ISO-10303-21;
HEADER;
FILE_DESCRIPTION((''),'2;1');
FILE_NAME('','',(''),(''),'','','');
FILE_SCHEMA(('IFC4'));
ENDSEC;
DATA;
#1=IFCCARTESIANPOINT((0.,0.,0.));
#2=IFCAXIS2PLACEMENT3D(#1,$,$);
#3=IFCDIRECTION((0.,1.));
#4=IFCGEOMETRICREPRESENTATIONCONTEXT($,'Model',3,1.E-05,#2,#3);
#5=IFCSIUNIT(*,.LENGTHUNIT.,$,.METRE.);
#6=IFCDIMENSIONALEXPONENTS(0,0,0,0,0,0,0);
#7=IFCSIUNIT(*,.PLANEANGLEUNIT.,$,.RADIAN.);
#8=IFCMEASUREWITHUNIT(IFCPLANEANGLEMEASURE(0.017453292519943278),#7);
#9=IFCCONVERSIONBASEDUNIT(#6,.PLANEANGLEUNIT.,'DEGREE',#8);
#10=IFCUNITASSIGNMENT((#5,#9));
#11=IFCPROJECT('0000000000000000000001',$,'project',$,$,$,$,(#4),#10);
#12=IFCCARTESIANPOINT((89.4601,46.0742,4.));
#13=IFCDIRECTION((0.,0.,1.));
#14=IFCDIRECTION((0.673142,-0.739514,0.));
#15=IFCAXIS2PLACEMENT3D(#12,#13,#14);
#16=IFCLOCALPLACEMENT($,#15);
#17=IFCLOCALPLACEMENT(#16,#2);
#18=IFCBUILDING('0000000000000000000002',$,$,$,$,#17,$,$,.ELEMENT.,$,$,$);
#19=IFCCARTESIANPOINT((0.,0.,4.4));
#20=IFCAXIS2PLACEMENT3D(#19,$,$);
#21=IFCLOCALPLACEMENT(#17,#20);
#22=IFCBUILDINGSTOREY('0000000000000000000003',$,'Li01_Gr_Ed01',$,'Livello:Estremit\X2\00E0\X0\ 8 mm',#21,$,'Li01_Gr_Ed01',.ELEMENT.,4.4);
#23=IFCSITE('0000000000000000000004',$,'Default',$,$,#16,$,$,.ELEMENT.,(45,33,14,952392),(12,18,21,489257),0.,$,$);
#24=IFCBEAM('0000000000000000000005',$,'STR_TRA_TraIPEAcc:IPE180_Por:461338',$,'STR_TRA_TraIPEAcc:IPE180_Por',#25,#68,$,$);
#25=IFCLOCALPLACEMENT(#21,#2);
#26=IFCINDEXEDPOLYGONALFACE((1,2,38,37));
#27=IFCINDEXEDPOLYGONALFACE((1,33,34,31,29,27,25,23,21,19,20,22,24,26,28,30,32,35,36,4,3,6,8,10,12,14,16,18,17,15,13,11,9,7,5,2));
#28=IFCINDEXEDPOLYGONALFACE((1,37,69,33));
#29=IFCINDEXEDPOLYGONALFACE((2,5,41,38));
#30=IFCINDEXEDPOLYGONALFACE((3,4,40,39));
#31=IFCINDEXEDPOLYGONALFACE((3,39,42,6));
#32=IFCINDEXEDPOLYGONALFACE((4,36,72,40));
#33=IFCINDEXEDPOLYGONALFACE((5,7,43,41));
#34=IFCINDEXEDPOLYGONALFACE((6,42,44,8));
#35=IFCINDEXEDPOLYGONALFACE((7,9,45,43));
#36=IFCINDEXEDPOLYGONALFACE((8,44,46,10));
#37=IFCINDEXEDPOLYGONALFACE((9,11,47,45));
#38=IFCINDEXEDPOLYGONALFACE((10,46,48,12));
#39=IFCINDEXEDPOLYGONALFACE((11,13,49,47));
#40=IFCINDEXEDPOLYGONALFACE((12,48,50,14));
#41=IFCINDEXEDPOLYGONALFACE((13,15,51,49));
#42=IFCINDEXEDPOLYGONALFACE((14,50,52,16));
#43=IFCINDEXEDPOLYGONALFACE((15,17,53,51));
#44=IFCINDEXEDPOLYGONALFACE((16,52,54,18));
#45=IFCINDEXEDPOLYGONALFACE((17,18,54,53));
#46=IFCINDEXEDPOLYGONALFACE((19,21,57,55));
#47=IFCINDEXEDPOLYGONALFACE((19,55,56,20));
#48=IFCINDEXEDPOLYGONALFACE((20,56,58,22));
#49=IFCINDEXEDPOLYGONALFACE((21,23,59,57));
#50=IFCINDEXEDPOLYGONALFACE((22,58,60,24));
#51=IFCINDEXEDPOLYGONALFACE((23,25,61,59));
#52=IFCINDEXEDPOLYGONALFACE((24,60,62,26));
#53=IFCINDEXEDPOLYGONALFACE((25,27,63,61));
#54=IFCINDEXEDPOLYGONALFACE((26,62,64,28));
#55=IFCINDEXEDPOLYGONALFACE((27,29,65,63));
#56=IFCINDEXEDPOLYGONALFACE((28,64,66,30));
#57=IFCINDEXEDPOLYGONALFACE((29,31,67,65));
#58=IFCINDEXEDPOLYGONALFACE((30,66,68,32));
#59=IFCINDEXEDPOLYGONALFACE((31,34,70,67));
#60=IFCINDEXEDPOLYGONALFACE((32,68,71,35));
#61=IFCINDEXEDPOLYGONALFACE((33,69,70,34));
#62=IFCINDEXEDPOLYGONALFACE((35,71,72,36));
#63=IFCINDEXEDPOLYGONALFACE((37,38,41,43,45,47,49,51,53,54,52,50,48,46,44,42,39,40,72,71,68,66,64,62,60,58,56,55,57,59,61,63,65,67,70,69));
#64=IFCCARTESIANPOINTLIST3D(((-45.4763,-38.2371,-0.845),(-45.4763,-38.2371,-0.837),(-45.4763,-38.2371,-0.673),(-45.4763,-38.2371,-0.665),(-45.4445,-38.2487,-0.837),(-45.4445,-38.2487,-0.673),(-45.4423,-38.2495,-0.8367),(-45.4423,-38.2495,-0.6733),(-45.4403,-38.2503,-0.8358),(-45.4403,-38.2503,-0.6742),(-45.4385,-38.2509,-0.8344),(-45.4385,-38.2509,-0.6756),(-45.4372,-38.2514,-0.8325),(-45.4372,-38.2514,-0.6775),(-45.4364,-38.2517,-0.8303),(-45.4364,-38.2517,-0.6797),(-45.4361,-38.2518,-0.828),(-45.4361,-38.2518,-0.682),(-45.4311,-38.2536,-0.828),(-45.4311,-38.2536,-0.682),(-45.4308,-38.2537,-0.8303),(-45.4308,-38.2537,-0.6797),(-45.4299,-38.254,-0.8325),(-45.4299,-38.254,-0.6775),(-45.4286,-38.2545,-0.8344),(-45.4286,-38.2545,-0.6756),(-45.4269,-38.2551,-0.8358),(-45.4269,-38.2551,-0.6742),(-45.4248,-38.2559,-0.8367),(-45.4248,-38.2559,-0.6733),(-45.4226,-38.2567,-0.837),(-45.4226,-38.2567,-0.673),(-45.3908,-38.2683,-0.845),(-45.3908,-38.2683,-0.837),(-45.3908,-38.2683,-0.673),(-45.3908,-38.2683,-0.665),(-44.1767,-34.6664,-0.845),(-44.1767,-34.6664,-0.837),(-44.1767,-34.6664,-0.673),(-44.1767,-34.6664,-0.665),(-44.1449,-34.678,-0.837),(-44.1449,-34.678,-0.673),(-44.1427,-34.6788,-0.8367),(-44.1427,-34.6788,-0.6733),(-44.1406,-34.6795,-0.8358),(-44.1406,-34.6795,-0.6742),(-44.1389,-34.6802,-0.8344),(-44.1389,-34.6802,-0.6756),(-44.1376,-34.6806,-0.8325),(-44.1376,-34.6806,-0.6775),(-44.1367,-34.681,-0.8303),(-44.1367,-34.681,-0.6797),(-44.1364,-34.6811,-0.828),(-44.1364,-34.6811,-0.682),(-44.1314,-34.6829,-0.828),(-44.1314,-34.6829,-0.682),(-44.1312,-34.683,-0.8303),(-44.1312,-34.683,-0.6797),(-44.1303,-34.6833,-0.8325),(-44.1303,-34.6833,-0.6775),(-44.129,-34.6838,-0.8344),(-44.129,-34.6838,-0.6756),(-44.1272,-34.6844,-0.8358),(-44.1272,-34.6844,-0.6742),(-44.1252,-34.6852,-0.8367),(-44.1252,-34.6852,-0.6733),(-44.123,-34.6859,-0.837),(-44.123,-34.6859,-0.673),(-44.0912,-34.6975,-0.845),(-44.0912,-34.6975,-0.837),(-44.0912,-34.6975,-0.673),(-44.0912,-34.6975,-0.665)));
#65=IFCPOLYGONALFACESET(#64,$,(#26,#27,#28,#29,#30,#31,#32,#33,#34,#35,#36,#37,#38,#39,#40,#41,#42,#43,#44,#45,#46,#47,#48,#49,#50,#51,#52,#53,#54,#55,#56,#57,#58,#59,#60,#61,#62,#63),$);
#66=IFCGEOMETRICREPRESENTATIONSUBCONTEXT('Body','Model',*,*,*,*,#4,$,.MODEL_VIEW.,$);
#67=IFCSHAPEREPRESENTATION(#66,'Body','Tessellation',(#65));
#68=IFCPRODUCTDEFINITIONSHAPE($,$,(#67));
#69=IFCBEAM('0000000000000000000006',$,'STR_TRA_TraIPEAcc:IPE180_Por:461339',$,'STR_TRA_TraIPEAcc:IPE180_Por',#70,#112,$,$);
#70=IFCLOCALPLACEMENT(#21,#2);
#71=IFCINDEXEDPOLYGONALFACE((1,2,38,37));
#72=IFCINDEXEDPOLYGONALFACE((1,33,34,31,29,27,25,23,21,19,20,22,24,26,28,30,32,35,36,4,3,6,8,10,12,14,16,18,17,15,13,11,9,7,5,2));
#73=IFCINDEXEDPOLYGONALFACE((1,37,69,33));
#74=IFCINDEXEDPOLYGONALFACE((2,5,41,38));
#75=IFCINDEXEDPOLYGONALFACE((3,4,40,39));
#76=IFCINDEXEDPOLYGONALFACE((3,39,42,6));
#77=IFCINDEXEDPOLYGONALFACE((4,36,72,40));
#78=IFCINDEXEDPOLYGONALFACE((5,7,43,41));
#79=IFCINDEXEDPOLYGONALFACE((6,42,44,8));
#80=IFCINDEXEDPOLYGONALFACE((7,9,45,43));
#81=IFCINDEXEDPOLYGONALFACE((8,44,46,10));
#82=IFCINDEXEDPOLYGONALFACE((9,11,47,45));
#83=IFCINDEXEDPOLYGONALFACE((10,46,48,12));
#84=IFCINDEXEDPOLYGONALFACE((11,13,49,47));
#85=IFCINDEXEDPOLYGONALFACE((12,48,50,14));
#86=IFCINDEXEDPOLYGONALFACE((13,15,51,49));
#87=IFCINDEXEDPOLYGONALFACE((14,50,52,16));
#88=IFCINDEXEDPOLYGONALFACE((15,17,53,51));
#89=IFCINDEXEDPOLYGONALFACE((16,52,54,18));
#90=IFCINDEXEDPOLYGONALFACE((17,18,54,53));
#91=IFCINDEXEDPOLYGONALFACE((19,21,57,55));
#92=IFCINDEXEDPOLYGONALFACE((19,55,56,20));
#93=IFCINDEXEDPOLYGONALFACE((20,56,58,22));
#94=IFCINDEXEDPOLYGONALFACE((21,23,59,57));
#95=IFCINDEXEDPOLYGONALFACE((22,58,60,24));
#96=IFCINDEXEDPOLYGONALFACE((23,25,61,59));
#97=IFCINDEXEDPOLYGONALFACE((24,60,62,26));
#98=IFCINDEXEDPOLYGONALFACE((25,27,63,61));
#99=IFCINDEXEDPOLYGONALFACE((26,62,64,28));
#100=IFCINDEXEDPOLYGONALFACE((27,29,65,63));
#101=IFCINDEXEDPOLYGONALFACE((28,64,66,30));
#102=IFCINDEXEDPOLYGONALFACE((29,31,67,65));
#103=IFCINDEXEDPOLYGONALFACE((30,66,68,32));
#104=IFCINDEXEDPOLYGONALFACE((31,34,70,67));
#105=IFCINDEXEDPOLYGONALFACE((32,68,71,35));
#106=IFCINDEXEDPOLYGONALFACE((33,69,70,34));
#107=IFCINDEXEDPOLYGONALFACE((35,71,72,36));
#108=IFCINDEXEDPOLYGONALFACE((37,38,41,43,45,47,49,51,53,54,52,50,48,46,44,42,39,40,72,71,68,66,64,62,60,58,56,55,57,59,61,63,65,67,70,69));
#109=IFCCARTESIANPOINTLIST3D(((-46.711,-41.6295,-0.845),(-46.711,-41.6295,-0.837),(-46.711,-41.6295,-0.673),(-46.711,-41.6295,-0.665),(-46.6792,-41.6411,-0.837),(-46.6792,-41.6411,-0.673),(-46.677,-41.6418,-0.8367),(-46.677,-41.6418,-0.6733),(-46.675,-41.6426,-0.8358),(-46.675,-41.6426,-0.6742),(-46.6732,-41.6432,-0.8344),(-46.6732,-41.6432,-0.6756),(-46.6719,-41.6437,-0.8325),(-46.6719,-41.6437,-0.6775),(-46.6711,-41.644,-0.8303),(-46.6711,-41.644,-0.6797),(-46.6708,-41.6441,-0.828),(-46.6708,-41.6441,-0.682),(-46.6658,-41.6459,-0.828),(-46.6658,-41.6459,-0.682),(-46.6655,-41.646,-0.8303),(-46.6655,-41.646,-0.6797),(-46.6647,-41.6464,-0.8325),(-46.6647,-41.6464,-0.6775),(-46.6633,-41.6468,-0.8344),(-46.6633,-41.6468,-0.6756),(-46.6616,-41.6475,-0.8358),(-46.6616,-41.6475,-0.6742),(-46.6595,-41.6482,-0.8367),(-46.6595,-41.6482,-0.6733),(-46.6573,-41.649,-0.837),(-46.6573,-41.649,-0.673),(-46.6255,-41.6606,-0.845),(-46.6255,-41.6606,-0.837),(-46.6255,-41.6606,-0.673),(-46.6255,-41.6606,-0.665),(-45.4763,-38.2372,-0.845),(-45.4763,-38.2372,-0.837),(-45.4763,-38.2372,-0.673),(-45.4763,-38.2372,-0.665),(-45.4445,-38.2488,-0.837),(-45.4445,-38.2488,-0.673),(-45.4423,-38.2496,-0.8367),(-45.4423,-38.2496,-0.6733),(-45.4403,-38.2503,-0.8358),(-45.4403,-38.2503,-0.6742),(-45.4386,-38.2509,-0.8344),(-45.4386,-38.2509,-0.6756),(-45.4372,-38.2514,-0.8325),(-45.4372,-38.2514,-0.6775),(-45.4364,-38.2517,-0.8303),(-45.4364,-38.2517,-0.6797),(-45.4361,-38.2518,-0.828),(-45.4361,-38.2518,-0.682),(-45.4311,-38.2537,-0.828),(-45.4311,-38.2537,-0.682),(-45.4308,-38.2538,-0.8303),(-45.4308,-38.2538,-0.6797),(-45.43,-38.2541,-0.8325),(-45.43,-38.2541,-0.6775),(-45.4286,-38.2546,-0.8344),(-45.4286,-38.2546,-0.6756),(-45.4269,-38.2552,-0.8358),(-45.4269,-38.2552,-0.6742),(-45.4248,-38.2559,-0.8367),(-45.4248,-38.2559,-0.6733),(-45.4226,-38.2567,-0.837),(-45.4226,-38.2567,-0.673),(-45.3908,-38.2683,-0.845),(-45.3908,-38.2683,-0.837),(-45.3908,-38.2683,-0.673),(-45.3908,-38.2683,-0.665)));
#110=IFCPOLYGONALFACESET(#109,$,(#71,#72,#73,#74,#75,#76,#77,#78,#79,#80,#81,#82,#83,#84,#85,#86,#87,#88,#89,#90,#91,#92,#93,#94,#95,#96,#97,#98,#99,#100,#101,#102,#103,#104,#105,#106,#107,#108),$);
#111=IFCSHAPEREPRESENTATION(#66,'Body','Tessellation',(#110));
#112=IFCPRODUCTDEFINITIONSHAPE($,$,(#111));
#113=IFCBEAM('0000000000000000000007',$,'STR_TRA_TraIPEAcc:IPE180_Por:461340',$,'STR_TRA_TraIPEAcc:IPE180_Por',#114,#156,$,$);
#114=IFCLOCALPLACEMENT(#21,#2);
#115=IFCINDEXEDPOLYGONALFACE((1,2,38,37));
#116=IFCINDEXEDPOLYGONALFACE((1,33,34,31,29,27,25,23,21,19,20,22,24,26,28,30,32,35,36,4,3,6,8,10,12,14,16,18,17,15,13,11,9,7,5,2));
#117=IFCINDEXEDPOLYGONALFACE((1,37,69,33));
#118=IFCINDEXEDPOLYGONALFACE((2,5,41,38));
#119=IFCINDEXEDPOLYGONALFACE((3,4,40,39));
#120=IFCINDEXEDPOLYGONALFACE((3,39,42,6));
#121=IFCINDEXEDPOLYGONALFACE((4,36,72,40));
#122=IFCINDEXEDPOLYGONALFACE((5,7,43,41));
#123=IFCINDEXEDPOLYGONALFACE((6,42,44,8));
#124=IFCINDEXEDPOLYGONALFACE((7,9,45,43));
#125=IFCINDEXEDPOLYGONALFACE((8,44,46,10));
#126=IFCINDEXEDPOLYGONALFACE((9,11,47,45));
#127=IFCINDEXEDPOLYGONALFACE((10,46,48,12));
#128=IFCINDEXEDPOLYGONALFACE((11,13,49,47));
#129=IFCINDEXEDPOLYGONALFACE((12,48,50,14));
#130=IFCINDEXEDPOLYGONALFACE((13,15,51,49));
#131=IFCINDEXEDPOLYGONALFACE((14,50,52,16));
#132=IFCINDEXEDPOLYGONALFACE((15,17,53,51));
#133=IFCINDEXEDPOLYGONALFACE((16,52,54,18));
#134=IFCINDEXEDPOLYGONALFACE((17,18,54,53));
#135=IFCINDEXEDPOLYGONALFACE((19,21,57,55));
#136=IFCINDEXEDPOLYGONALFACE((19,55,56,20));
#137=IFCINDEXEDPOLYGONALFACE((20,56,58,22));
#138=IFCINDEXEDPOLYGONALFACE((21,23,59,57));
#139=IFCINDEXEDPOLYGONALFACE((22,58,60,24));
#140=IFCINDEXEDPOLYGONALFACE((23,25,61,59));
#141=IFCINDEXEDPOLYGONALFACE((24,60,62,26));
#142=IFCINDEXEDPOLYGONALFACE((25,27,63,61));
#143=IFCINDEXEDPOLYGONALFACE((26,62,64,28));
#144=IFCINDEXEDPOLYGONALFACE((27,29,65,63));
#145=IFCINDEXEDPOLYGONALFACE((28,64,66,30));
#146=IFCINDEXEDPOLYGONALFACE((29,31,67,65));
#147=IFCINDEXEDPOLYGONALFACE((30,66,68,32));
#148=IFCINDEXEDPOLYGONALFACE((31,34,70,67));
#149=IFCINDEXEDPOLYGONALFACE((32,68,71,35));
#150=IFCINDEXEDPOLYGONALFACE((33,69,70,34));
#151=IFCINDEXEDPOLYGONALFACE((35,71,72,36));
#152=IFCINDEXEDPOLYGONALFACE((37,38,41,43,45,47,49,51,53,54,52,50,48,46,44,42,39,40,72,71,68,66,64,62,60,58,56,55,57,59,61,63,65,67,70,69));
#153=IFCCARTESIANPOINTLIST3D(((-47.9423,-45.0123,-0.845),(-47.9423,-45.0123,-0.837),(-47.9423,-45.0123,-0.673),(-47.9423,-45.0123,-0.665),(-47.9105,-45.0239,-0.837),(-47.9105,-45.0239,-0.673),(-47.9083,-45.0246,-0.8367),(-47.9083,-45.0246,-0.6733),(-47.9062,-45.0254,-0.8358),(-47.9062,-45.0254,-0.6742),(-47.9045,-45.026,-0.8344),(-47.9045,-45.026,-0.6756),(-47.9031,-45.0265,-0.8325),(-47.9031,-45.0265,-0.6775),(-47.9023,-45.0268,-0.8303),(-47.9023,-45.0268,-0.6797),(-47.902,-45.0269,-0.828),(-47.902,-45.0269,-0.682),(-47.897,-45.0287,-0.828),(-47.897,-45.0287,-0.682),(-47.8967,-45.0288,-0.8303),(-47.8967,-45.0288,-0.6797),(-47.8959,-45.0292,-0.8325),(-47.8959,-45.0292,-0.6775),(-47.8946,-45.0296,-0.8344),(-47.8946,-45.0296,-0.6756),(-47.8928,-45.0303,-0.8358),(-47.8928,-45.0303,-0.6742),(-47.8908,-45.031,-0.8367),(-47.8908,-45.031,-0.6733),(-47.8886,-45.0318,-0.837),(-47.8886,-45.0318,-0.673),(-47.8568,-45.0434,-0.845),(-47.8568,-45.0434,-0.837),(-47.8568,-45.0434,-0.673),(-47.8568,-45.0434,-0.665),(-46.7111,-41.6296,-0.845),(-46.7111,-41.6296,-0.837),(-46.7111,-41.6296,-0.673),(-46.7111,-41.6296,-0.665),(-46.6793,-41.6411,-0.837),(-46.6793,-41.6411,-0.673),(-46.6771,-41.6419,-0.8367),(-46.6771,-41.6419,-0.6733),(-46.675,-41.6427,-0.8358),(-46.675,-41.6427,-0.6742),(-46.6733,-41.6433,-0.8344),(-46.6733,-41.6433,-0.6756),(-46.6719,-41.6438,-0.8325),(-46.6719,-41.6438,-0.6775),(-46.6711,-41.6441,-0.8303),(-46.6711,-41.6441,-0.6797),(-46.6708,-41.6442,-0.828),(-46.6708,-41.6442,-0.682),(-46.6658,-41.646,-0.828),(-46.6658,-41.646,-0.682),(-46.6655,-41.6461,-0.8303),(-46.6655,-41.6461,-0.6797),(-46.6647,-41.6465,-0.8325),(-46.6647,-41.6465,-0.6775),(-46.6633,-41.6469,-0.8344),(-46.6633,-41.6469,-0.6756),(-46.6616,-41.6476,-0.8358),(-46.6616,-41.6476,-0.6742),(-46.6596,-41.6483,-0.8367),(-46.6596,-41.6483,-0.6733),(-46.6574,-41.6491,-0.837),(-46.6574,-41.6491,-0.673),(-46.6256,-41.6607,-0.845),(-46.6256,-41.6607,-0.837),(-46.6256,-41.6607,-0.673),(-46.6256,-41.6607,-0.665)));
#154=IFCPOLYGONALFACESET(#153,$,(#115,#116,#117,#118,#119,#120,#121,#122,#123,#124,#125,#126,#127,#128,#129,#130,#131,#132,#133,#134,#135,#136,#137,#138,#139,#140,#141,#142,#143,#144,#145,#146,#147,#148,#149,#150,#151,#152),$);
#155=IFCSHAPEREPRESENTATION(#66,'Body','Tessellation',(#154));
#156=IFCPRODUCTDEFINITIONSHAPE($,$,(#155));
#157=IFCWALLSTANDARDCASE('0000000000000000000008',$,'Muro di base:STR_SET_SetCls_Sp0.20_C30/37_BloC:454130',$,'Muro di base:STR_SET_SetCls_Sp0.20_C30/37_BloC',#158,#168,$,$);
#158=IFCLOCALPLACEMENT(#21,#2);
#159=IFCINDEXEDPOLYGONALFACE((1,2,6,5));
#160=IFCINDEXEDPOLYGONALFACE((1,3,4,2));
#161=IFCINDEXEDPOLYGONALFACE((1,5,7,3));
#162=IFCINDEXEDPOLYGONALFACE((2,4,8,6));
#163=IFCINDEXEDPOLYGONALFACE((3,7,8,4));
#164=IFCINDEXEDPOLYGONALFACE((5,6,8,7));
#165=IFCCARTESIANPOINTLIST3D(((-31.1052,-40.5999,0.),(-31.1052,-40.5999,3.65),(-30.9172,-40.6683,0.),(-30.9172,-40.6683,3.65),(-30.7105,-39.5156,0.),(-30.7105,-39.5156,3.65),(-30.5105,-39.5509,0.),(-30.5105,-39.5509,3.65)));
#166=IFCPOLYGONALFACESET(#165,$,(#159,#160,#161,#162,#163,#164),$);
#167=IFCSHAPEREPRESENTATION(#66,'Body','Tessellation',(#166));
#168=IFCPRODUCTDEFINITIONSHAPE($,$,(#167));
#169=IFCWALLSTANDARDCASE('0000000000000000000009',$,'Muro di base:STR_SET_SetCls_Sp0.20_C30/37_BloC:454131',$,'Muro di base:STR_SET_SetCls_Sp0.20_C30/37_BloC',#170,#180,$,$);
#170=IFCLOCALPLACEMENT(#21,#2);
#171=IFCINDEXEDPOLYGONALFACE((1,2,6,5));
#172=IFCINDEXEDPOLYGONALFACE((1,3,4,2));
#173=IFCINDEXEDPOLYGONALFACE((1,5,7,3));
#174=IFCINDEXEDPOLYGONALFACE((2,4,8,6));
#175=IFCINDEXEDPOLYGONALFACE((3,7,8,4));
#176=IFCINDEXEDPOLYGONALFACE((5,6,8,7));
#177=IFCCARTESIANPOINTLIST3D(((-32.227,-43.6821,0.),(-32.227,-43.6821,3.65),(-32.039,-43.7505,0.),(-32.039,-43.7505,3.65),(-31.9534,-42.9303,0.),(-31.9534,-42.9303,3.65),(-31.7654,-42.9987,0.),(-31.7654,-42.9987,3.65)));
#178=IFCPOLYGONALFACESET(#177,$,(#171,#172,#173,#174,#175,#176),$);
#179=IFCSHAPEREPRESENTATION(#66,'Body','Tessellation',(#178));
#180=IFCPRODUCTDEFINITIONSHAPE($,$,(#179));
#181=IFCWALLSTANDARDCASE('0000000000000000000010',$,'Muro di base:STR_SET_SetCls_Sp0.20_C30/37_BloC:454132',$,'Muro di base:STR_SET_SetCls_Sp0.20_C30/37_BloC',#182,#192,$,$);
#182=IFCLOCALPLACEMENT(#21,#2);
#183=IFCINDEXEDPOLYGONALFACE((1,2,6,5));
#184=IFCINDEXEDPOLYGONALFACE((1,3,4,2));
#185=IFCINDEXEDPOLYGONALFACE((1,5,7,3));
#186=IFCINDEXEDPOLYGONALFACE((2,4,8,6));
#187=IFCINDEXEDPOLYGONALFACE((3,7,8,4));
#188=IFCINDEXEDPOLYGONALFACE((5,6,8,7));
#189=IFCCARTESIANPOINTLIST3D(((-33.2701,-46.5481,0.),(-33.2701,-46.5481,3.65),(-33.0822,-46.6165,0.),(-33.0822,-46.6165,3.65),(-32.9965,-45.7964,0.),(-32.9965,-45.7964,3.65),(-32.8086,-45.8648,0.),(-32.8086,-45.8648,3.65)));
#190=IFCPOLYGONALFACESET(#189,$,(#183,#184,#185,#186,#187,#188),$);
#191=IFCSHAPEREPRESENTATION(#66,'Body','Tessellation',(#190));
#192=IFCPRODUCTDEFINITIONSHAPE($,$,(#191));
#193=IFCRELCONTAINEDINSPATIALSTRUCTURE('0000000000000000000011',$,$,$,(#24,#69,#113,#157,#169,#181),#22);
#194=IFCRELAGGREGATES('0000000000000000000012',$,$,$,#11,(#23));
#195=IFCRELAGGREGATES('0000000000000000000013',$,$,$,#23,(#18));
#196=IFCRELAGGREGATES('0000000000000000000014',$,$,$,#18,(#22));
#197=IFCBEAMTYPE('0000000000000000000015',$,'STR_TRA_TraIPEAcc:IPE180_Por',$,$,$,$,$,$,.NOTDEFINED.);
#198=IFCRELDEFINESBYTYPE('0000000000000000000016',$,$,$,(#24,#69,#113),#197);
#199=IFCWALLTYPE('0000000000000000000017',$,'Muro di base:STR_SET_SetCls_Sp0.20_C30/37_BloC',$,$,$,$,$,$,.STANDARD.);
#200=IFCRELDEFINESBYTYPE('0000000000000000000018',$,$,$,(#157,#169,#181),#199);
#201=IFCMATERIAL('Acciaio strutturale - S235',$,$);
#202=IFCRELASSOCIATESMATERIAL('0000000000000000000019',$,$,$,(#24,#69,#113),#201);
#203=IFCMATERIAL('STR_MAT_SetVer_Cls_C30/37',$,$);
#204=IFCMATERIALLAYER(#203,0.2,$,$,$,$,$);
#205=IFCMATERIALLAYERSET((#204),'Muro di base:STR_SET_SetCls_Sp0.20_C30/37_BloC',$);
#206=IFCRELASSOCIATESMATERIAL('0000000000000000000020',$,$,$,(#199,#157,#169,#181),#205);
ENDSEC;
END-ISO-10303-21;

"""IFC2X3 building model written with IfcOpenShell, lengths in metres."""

from ifc_helpers import new_model, entity, si_unit, converted_unit, direction, frame, frame_2d, origin, place, context, subcontext, project, spatial, polyline, rectangle, i_section, outline, extrude, material, layer, layer_set, layer_usage, type_object, element, save


model = new_model("IFC2X3")

# Units and contexts
model_context = context("Model", 3, precision=1e-05, world=origin(), true_north=direction((0.0, 1.0)))
body_context = subcontext(model_context, "Body", "Model", "MODEL_VIEW")
ifc_project = project(units=[si_unit("LENGTHUNIT", "METRE"), converted_unit("PLANEANGLEUNIT", "DEGREE", entity("IfcPlaneAngleMeasure", 0.017453292519943278), si_unit("PLANEANGLEUNIT", "RADIAN"), dimensions=[0, 0, 0, 0, 0, 0, 0])], contexts=[model_context])

# Site, building, storey
site_placement = place(None, frame((89.4601, 46.0742, 4.0), z_axis=(0.0, 0.0, 1.0), x_axis=(0.673142, -0.739514, 0.0)))
site = spatial("IfcSite", under=ifc_project, at=site_placement, Name="Default", CompositionType="ELEMENT", RefLatitude=(45, 33, 14, 952392), RefLongitude=(12, 18, 21, 489257), RefElevation=0.0)
building_placement = place(site_placement, origin())
building = spatial("IfcBuilding", under=site, at=building_placement, CompositionType="ELEMENT")
storey_placement = place(building_placement, frame((0.0, 0.0, 4.4)))
storey = spatial("IfcBuildingStorey", under=building, at=storey_placement, Name="Li01_Gr_Ed01", ObjectType="Livello:Estremità 8 mm", LongName="Li01_Gr_Ed01", CompositionType="ELEMENT", Elevation=4.4)

# Beams
ifc_material_1 = material(Name="Acciaio strutturale - S235")
beam_type = type_object("IfcBeamType", Name="STR_TRA_TraIPEAcc:IPE180_Por", PredefinedType="NOTDEFINED")
beam_1_placement = place(storey_placement, frame((-45.4336, -38.2527, -0.665), z_axis=(0.0, 0.0, 1.0), x_axis=(0.34202, 0.939693, 0.0)))
element("IfcBeam", 1, at=beam_1_placement, inside=storey, type_object=beam_type, material=ifc_material_1, Name="STR_TRA_TraIPEAcc:IPE180_Por:461338", ObjectType="STR_TRA_TraIPEAcc:IPE180_Por", context=body_context, shape_type="SweptSolid", body=[
    extrude(i_section(OverallWidth=0.091, OverallDepth=0.18, WebThickness=0.0053, FlangeThickness=0.008, FilletRadius=0.009, at=frame_2d((0.0, 0.0), x_axis=(0.0, 1.0))), frame((0.0, 0.0, -0.09), z_axis=(1.0, 0.0, 0.0), x_axis=(0.0, 0.0, -1.0)), (0.0, 0.0, 1.0), 3.7999),
])
beam_2_placement = place(storey_placement, frame((-46.6683, -41.645, -0.665), z_axis=(0.0, 0.0, 1.0), x_axis=(0.34202, 0.939693, 0.0)))
element("IfcBeam", 2, at=beam_2_placement, inside=storey, type_object=beam_type, material=ifc_material_1, Name="STR_TRA_TraIPEAcc:IPE180_Por:461339", ObjectType="STR_TRA_TraIPEAcc:IPE180_Por", context=body_context, shape_type="SweptSolid", body=[
    extrude(i_section(OverallWidth=0.091, OverallDepth=0.18, WebThickness=0.0053, FlangeThickness=0.008, FilletRadius=0.009, at=frame_2d((0.0, 0.0), x_axis=(0.0, 1.0))), frame((0.0, 0.0, -0.09), z_axis=(1.0, 0.0, 0.0), x_axis=(0.0, 0.0, -1.0)), (0.0, 0.0, 1.0), 3.61),
])
beam_3_placement = place(storey_placement, frame((-47.8996, -45.0279, -0.665), z_axis=(0.0, 0.0, 1.0), x_axis=(0.34202, 0.939693, 0.0)))
element("IfcBeam", 3, at=beam_3_placement, inside=storey, type_object=beam_type, material=ifc_material_1, Name="STR_TRA_TraIPEAcc:IPE180_Por:461340", ObjectType="STR_TRA_TraIPEAcc:IPE180_Por", context=body_context, shape_type="SweptSolid", body=[
    extrude(i_section(OverallWidth=0.091, OverallDepth=0.18, WebThickness=0.0053, FlangeThickness=0.008, FilletRadius=0.009, at=frame_2d((0.0, 0.0), x_axis=(0.0, 1.0))), frame((0.0001, 0.0, -0.09), z_axis=(1.0, 0.0, 0.0), x_axis=(0.0, 0.0, -1.0)), (0.0, 0.0, 1.0), 3.5998),
])

# Walls
ifc_material_2 = material(Name="STR_MAT_SetVer_Cls_C30/37")
ifc_layer_1 = layer(ifc_material_2, 0.2)
ifc_layer_set_1 = layer_set([ifc_layer_1], Name="Muro di base:STR_SET_SetCls_Sp0.20_C30/37_BloC")
ifc_layer_usage_1 = layer_usage(ifc_layer_set_1, "AXIS2", "NEGATIVE", 0.1)
wall_type_1 = type_object("IfcWallType", Name="Muro di base:STR_SET_SetCls_Sp0.20_C30/37_BloC", PredefinedType="STANDARD", material=ifc_layer_set_1)
wall_1_placement = place(storey_placement, frame((-31.0112, -40.6341, 0.0), z_axis=(0.0, 0.0, 1.0), x_axis=(0.34202, 0.939693, 0.0)))
element("IfcWallStandardCase", 4, at=wall_1_placement, inside=storey, type_object=wall_type_1, material=ifc_layer_usage_1, Name="Muro di base:STR_SET_SetCls_Sp0.20_C30/37_BloC:454130", ObjectType="Muro di base:STR_SET_SetCls_Sp0.20_C30/37_BloC", context=body_context, shape_type="SweptSolid", body=[
    extrude(outline(polyline([(1.1891, -0.1), (1.1539, 0.1), (0.0, 0.1), (0.0, -0.1), (1.1891, -0.1)])), origin(), (0.0, 0.0, 1.0), 3.65),
])
wall_2_placement = place(storey_placement, frame((-32.133, -43.7163, 0.0), z_axis=(0.0, 0.0, 1.0), x_axis=(0.34202, 0.939693, 0.0)))
element("IfcWallStandardCase", 5, at=wall_2_placement, inside=storey, type_object=wall_type_1, material=ifc_layer_usage_1, Name="Muro di base:STR_SET_SetCls_Sp0.20_C30/37_BloC:454131", ObjectType="Muro di base:STR_SET_SetCls_Sp0.20_C30/37_BloC", context=body_context, shape_type="SweptSolid", body=[
    extrude(rectangle(XDim=0.8, YDim=0.2, at=frame_2d((0.4, 0.0), x_axis=(-1.0, 0.0))), origin(), (0.0, 0.0, 1.0), 3.65),
])
wall_3_placement = place(storey_placement, frame((-33.1762, -46.5823, 0.0), z_axis=(0.0, 0.0, 1.0), x_axis=(0.34202, 0.939693, 0.0)))
element("IfcWallStandardCase", 6, at=wall_3_placement, inside=storey, type_object=wall_type_1, material=ifc_layer_usage_1, Name="Muro di base:STR_SET_SetCls_Sp0.20_C30/37_BloC:454132", ObjectType="Muro di base:STR_SET_SetCls_Sp0.20_C30/37_BloC", context=body_context, shape_type="SweptSolid", body=[
    extrude(rectangle(XDim=0.8, YDim=0.2, at=frame_2d((0.4, 0.0), x_axis=(-1.0, 0.0))), origin(), (0.0, 0.0, 1.0), 3.65),
])

save(model, "model.ifc")
